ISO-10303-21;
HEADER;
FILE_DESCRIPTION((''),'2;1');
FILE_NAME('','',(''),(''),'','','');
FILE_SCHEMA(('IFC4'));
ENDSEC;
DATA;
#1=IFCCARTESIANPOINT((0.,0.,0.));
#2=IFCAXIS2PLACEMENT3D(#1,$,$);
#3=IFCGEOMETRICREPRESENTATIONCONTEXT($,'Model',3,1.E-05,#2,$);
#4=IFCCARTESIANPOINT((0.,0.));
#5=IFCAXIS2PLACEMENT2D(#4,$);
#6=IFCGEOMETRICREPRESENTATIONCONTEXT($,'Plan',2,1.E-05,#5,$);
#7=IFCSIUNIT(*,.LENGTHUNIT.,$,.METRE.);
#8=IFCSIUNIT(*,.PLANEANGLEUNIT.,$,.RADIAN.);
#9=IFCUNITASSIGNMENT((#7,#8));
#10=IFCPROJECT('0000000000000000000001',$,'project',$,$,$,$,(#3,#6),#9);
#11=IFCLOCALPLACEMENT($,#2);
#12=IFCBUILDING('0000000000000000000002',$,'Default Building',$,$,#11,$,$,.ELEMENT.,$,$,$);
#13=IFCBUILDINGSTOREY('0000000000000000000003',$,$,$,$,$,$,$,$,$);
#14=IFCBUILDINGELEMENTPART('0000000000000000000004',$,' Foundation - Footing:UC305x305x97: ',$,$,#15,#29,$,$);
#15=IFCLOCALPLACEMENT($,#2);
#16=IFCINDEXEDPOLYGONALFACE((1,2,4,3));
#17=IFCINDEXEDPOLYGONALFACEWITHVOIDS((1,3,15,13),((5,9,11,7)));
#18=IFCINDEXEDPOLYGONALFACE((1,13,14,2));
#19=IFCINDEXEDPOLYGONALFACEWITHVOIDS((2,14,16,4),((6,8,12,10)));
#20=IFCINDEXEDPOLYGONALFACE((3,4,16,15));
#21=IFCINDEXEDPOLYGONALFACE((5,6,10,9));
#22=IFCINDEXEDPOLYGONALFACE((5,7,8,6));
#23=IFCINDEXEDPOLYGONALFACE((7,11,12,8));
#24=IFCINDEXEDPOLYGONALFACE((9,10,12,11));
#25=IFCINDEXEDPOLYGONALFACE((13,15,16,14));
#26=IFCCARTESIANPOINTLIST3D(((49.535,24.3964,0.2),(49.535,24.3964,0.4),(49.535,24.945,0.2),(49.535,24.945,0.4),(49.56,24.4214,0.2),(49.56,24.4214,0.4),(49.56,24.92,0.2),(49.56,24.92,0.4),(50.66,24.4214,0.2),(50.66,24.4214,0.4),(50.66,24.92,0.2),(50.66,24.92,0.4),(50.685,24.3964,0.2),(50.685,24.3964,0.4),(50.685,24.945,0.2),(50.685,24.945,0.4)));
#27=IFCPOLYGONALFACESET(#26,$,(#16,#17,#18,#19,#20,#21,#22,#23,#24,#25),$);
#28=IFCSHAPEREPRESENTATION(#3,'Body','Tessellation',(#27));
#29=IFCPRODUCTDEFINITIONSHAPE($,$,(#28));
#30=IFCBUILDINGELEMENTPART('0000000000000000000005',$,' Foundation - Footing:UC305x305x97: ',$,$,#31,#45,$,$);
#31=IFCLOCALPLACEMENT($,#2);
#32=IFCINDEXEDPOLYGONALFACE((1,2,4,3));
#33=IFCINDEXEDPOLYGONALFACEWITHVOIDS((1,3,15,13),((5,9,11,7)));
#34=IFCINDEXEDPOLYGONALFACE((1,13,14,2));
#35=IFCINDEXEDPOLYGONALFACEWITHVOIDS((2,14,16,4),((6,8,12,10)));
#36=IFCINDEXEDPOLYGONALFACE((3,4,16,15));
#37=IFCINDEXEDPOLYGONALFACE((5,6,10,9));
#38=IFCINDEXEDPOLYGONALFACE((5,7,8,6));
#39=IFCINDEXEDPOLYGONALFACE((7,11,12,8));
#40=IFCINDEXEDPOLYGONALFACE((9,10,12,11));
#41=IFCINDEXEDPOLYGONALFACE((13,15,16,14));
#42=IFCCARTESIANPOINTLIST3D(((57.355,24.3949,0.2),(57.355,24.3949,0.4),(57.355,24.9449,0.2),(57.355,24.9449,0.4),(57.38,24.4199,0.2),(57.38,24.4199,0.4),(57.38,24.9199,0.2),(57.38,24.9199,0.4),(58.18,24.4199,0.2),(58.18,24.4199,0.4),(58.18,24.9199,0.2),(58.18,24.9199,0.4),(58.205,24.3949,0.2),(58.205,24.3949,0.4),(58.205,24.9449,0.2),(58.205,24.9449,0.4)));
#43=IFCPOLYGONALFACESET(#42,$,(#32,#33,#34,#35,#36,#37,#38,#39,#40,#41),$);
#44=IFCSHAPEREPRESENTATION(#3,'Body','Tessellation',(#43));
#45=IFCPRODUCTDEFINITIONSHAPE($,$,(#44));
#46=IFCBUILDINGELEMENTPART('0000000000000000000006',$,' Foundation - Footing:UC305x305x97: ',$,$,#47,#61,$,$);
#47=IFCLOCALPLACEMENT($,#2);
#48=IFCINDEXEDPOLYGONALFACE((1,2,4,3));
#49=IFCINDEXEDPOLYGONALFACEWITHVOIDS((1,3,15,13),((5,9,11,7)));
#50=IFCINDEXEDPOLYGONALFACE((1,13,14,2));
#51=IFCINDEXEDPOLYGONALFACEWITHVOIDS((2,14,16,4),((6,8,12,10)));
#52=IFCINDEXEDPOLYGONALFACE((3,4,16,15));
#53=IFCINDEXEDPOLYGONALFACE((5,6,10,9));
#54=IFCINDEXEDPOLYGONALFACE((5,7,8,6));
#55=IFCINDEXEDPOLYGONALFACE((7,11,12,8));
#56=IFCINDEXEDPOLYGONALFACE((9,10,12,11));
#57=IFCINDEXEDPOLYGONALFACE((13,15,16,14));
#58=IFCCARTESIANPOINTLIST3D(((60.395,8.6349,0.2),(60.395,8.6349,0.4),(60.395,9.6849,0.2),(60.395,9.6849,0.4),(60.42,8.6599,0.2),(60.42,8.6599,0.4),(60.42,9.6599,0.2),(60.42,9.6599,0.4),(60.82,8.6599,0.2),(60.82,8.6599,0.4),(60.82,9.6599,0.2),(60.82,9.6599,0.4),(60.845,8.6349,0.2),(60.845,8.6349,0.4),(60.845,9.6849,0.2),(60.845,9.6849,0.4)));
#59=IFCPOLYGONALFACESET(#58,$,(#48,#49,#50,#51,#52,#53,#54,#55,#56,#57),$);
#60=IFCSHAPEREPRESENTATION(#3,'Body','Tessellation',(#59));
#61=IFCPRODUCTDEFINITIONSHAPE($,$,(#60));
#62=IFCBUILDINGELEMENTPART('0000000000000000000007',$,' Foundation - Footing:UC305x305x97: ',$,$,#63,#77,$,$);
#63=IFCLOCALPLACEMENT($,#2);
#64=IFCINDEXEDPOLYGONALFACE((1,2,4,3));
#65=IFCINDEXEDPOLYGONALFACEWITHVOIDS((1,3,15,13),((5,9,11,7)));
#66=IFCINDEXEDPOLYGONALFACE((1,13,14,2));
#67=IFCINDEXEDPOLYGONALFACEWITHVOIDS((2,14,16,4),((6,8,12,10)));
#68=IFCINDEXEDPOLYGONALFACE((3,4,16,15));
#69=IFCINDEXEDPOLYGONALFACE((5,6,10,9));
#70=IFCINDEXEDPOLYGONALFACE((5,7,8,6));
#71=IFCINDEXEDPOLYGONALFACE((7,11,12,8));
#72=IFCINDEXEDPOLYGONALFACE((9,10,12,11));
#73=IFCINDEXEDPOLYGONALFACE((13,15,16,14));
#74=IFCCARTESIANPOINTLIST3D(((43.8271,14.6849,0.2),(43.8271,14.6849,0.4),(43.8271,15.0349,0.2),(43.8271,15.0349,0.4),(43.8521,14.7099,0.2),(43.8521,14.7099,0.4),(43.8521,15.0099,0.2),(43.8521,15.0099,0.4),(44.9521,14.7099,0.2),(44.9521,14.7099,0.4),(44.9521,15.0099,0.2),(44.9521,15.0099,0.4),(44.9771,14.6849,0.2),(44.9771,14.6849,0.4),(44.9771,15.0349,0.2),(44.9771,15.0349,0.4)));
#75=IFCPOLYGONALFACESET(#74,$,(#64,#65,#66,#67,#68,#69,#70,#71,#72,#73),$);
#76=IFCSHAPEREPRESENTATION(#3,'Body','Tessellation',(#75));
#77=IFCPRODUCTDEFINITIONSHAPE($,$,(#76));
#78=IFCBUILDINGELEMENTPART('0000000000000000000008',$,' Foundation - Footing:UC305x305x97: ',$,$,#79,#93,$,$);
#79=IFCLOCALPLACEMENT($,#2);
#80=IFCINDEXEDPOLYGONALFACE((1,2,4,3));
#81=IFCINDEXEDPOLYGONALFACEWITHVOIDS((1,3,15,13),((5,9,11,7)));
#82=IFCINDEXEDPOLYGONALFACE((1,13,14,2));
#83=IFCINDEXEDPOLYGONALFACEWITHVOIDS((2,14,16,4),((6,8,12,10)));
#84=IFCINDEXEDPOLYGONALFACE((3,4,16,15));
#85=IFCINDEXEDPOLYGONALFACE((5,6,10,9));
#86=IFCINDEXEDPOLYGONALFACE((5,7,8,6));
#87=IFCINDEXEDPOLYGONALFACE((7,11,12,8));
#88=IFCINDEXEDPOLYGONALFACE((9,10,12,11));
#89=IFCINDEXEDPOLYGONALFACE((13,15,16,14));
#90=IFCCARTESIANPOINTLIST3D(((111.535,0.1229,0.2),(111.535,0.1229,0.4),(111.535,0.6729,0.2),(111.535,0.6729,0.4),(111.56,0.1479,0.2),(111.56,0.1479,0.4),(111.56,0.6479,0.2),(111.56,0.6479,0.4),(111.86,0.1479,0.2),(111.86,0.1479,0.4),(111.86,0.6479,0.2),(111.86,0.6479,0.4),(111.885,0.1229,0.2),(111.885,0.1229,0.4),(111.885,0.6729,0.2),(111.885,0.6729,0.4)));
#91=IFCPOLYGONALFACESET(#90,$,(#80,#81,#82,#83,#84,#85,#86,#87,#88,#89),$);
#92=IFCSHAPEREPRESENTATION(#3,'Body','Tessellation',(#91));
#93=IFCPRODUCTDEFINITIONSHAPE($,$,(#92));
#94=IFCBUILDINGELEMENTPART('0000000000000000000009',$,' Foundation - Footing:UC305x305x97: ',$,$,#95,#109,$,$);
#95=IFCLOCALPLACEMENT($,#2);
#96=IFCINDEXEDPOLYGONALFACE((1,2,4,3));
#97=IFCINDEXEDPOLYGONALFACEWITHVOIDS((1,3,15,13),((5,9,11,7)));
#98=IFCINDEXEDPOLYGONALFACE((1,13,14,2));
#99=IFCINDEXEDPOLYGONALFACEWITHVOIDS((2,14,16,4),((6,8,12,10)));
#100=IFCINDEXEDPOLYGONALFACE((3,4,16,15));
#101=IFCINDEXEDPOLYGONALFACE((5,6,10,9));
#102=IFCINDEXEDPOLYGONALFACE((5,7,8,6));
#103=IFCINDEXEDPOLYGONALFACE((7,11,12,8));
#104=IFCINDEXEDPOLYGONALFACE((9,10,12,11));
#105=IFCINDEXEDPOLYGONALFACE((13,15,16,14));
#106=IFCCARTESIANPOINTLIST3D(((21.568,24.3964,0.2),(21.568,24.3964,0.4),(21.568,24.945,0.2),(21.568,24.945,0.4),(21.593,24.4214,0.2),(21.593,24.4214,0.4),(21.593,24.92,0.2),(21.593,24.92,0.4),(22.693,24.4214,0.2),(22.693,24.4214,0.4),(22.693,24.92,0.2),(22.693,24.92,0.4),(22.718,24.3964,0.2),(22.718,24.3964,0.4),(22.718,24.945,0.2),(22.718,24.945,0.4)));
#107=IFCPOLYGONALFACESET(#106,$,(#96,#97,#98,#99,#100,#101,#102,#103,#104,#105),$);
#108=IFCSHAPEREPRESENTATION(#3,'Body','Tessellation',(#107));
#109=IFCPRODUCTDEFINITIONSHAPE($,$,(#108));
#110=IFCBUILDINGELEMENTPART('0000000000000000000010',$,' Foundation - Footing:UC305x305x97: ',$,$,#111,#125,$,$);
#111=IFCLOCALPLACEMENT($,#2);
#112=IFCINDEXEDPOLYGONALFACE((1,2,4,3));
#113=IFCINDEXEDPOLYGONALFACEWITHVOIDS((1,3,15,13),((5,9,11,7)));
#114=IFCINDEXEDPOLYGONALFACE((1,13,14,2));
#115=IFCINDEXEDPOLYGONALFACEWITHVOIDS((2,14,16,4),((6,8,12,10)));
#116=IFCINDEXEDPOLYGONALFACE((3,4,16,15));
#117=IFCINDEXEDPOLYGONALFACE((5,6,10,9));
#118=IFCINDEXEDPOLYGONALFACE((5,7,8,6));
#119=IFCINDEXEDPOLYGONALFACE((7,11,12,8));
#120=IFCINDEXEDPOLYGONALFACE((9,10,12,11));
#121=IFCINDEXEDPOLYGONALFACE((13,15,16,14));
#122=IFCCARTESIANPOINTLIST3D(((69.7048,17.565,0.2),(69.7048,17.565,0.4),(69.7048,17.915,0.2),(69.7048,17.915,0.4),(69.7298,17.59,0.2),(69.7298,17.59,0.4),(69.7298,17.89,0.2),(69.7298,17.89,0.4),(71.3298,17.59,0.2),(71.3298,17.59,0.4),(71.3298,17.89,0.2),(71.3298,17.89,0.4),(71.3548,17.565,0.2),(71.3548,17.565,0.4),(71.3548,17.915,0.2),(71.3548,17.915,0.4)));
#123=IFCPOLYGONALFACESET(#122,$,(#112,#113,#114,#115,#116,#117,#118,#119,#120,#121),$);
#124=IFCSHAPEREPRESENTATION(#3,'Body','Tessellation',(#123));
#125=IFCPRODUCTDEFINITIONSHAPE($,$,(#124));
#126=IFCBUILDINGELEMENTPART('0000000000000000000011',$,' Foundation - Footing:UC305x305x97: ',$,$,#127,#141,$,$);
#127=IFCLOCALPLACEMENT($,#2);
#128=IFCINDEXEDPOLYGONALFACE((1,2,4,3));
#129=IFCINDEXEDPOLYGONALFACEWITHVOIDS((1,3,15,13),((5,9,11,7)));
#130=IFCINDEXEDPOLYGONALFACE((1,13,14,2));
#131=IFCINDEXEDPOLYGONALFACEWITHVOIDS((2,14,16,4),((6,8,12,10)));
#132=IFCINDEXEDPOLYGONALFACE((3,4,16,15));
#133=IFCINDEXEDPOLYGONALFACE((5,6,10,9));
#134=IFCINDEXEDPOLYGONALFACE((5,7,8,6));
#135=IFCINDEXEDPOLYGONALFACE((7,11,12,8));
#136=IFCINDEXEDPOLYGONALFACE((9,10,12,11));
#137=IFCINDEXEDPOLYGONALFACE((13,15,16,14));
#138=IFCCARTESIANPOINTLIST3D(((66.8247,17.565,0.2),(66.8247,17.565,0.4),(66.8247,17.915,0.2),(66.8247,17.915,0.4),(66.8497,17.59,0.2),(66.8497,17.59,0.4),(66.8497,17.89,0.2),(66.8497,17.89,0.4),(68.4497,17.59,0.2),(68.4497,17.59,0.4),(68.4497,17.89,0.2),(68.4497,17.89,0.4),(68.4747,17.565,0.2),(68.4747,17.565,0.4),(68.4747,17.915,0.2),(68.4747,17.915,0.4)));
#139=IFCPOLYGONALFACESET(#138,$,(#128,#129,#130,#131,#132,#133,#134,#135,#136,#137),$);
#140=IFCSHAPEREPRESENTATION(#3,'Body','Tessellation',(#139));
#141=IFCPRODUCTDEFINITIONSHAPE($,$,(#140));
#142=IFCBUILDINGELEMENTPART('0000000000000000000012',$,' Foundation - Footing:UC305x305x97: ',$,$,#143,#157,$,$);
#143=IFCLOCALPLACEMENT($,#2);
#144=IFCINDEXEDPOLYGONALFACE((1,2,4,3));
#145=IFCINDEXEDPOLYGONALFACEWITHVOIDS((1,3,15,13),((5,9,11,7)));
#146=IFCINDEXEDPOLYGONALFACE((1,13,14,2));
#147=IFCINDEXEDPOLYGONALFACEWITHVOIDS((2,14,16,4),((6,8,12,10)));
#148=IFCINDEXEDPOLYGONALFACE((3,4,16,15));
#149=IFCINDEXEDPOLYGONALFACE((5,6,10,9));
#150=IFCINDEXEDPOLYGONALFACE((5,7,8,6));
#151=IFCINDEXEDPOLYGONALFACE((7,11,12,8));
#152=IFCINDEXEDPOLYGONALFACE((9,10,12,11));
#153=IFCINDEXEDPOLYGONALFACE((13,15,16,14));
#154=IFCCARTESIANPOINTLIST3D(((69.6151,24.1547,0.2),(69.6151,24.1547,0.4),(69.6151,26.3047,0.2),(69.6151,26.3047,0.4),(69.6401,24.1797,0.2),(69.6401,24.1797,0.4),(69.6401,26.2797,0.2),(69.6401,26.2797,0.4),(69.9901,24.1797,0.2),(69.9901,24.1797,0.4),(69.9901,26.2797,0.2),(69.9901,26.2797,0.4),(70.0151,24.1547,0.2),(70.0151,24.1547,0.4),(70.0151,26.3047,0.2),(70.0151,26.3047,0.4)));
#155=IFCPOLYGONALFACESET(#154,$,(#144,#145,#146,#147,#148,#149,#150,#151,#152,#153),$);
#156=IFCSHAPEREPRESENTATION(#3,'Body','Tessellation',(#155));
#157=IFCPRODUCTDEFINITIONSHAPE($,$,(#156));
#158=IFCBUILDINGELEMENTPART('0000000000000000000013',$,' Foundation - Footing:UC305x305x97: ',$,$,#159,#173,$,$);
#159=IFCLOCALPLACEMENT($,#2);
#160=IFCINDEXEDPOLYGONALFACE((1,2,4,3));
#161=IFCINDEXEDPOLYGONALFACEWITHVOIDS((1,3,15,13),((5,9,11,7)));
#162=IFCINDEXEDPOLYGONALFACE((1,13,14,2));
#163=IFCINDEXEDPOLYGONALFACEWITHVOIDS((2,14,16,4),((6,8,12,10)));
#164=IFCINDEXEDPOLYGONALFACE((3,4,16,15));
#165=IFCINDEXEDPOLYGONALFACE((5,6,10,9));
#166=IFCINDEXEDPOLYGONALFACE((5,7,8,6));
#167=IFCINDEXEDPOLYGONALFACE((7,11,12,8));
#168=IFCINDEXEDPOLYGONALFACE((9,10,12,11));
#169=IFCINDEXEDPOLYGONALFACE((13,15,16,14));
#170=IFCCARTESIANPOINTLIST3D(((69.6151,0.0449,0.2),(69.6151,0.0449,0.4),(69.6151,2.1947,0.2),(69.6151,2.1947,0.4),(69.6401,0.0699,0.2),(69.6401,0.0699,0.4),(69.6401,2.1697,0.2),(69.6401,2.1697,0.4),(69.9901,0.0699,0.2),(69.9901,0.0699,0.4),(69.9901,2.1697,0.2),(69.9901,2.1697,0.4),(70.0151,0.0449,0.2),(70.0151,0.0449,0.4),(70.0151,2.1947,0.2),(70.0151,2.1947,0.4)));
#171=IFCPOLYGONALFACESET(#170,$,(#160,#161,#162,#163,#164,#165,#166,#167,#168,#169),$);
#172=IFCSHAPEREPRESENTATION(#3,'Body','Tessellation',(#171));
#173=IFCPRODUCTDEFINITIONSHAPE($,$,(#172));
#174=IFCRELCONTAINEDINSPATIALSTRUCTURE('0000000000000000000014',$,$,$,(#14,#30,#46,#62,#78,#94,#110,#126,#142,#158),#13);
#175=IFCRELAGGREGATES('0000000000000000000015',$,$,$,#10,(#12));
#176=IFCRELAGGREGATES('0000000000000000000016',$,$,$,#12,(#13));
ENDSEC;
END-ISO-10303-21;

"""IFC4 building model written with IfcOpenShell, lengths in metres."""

from ifc_helpers import new_model, si_unit, origin, origin_2d, place, context, project, spatial, polyline, outline, extrude, element, save


model = new_model("IFC4")

# Units and contexts
model_context = context("Model", 3, precision=1e-05, world=origin())
plan_context = context("Plan", 2, precision=1e-05, world=origin_2d())
ifc_project = project(units=[si_unit("LENGTHUNIT", "METRE"), si_unit("PLANEANGLEUNIT", "RADIAN")], contexts=[model_context, plan_context])

# Building, storey
building_placement = place(None, origin())
building = spatial("IfcBuilding", under=ifc_project, at=building_placement, Name="Default Building", CompositionType="ELEMENT")
storey = spatial("IfcBuildingStorey", under=building)

# Building element parts, openings
building_element_part_1 = element("IfcBuildingElementPart", 1, inside=storey, Name=" Foundation - Footing:UC305x305x97: ", context=model_context, shape_type="SweptSolid", body=[
    extrude(outline(polyline([(50.685, 24.3964, 0.2), (49.535, 24.3964, 0.2), (49.535, 24.945, 0.2), (50.685, 24.945, 0.2), (50.685, 24.3964, 0.2)])), None, (0.0, 0.0, 1.0), 0.2),
])
element("IfcOpeningElement", 2, inside=storey, cuts=building_element_part_1, context=model_context, shape_type="SweptSolid", body=[
    extrude(outline(polyline([(50.66, 24.4214, 0.2), (49.56, 24.4214, 0.2), (49.56, 24.92, 0.2), (50.66, 24.92, 0.2), (50.66, 24.4214, 0.2)])), None, (0.0, 0.0, 1.0), 0.2),
])
building_element_part_2 = element("IfcBuildingElementPart", 3, inside=storey, Name=" Foundation - Footing:UC305x305x97: ", context=model_context, shape_type="SweptSolid", body=[
    extrude(outline(polyline([(57.355, 24.3949, 0.2), (58.205, 24.3949, 0.2), (58.205, 24.9449, 0.2), (57.355, 24.9449, 0.2), (57.355, 24.3949, 0.2)])), None, (0.0, 0.0, 1.0), 0.2),
])
element("IfcOpeningElement", 4, inside=storey, cuts=building_element_part_2, context=model_context, shape_type="SweptSolid", body=[
    extrude(outline(polyline([(57.38, 24.4199, 0.2), (58.18, 24.4199, 0.2), (58.18, 24.9199, 0.2), (57.38, 24.9199, 0.2), (57.38, 24.4199, 0.2)])), None, (0.0, 0.0, 1.0), 0.2),
])
building_element_part_3 = element("IfcBuildingElementPart", 5, inside=storey, Name=" Foundation - Footing:UC305x305x97: ", context=model_context, shape_type="SweptSolid", body=[
    extrude(outline(polyline([(60.395, 8.6349, 0.2), (60.845, 8.6349, 0.2), (60.845, 9.6849, 0.2), (60.395, 9.6849, 0.2), (60.395, 8.6349, 0.2)])), None, (0.0, 0.0, 1.0), 0.2),
])
element("IfcOpeningElement", 6, inside=storey, cuts=building_element_part_3, context=model_context, shape_type="SweptSolid", body=[
    extrude(outline(polyline([(60.42, 8.6599, 0.2), (60.82, 8.6599, 0.2), (60.82, 9.6599, 0.2), (60.42, 9.6599, 0.2), (60.42, 8.6599, 0.2)])), None, (0.0, 0.0, 1.0), 0.2),
])
building_element_part_4 = element("IfcBuildingElementPart", 7, inside=storey, Name=" Foundation - Footing:UC305x305x97: ", context=model_context, shape_type="SweptSolid", body=[
    extrude(outline(polyline([(44.9771, 14.6849, 0.2), (44.9771, 15.0349, 0.2), (43.8271, 15.0349, 0.2), (43.8271, 14.6849, 0.2), (44.9771, 14.6849, 0.2)])), None, (0.0, 0.0, 1.0), 0.2),
])
element("IfcOpeningElement", 8, inside=storey, cuts=building_element_part_4, context=model_context, shape_type="SweptSolid", body=[
    extrude(outline(polyline([(44.9521, 14.7099, 0.2), (44.9521, 15.0099, 0.2), (43.8521, 15.0099, 0.2), (43.8521, 14.7099, 0.2), (44.9521, 14.7099, 0.2)])), None, (0.0, 0.0, 1.0), 0.2),
])
building_element_part_5 = element("IfcBuildingElementPart", 9, inside=storey, Name=" Foundation - Footing:UC305x305x97: ", context=model_context, shape_type="SweptSolid", body=[
    extrude(outline(polyline([(111.535, 0.6729, 0.2), (111.885, 0.6729, 0.2), (111.885, 0.1229, 0.2), (111.535, 0.1229, 0.2), (111.535, 0.6729, 0.2)])), None, (0.0, 0.0, 1.0), 0.2),
])
element("IfcOpeningElement", 10, inside=storey, cuts=building_element_part_5, context=model_context, shape_type="SweptSolid", body=[
    extrude(outline(polyline([(111.56, 0.6479, 0.2), (111.86, 0.6479, 0.2), (111.86, 0.1479, 0.2), (111.56, 0.1479, 0.2), (111.56, 0.6479, 0.2)])), None, (0.0, 0.0, 1.0), 0.2),
])
building_element_part_6 = element("IfcBuildingElementPart", 11, inside=storey, Name=" Foundation - Footing:UC305x305x97: ", context=model_context, shape_type="SweptSolid", body=[
    extrude(outline(polyline([(21.568, 24.3964, 0.2), (22.718, 24.3964, 0.2), (22.718, 24.945, 0.2), (21.568, 24.945, 0.2), (21.568, 24.3964, 0.2)])), None, (0.0, 0.0, 1.0), 0.2),
])
element("IfcOpeningElement", 12, inside=storey, cuts=building_element_part_6, context=model_context, shape_type="SweptSolid", body=[
    extrude(outline(polyline([(21.593, 24.4214, 0.2), (22.693, 24.4214, 0.2), (22.693, 24.92, 0.2), (21.593, 24.92, 0.2), (21.593, 24.4214, 0.2)])), None, (0.0, 0.0, 1.0), 0.2),
])
building_element_part_7 = element("IfcBuildingElementPart", 13, inside=storey, Name=" Foundation - Footing:UC305x305x97: ", context=model_context, shape_type="SweptSolid", body=[
    extrude(outline(polyline([(69.7048, 17.565, 0.2), (69.7048, 17.915, 0.2), (71.3548, 17.915, 0.2), (71.3548, 17.565, 0.2), (69.7048, 17.565, 0.2)])), None, (0.0, 0.0, 1.0), 0.2),
])
element("IfcOpeningElement", 14, inside=storey, cuts=building_element_part_7, context=model_context, shape_type="SweptSolid", body=[
    extrude(outline(polyline([(69.7298, 17.59, 0.2), (69.7298, 17.89, 0.2), (71.3298, 17.89, 0.2), (71.3298, 17.59, 0.2), (69.7298, 17.59, 0.2)])), None, (0.0, 0.0, 1.0), 0.2),
])
building_element_part_8 = element("IfcBuildingElementPart", 15, inside=storey, Name=" Foundation - Footing:UC305x305x97: ", context=model_context, shape_type="SweptSolid", body=[
    extrude(outline(polyline([(66.8247, 17.565, 0.2), (66.8247, 17.915, 0.2), (68.4747, 17.915, 0.2), (68.4747, 17.565, 0.2), (66.8247, 17.565, 0.2)])), None, (0.0, 0.0, 1.0), 0.2),
])
element("IfcOpeningElement", 16, inside=storey, cuts=building_element_part_8, context=model_context, shape_type="SweptSolid", body=[
    extrude(outline(polyline([(66.8497, 17.59, 0.2), (66.8497, 17.89, 0.2), (68.4497, 17.89, 0.2), (68.4497, 17.59, 0.2), (66.8497, 17.59, 0.2)])), None, (0.0, 0.0, 1.0), 0.2),
])
building_element_part_9 = element("IfcBuildingElementPart", 17, inside=storey, Name=" Foundation - Footing:UC305x305x97: ", context=model_context, shape_type="SweptSolid", body=[
    extrude(outline(polyline([(70.0151, 26.3047, 0.2), (69.6151, 26.3047, 0.2), (69.6151, 24.1547, 0.2), (70.0151, 24.1547, 0.2), (70.0151, 26.3047, 0.2)])), None, (0.0, 0.0, 1.0), 0.2),
])
element("IfcOpeningElement", 18, inside=storey, cuts=building_element_part_9, context=model_context, shape_type="SweptSolid", body=[
    extrude(outline(polyline([(69.9901, 26.2797, 0.2), (69.6401, 26.2797, 0.2), (69.6401, 24.1797, 0.2), (69.9901, 24.1797, 0.2), (69.9901, 26.2797, 0.2)])), None, (0.0, 0.0, 1.0), 0.2),
])
building_element_part_10 = element("IfcBuildingElementPart", 19, inside=storey, Name=" Foundation - Footing:UC305x305x97: ", context=model_context, shape_type="SweptSolid", body=[
    extrude(outline(polyline([(70.0151, 2.1947, 0.2), (69.6151, 2.1947, 0.2), (69.6151, 0.0449, 0.2), (70.0151, 0.0449, 0.2), (70.0151, 2.1947, 0.2)])), None, (0.0, 0.0, 1.0), 0.2),
])
element("IfcOpeningElement", 20, inside=storey, cuts=building_element_part_10, context=model_context, shape_type="SweptSolid", body=[
    extrude(outline(polyline([(69.9901, 2.1697, 0.2), (69.6401, 2.1697, 0.2), (69.6401, 0.0699, 0.2), (69.9901, 0.0699, 0.2), (69.9901, 2.1697, 0.2)])), None, (0.0, 0.0, 1.0), 0.2),
])

save(model, "model.ifc")
